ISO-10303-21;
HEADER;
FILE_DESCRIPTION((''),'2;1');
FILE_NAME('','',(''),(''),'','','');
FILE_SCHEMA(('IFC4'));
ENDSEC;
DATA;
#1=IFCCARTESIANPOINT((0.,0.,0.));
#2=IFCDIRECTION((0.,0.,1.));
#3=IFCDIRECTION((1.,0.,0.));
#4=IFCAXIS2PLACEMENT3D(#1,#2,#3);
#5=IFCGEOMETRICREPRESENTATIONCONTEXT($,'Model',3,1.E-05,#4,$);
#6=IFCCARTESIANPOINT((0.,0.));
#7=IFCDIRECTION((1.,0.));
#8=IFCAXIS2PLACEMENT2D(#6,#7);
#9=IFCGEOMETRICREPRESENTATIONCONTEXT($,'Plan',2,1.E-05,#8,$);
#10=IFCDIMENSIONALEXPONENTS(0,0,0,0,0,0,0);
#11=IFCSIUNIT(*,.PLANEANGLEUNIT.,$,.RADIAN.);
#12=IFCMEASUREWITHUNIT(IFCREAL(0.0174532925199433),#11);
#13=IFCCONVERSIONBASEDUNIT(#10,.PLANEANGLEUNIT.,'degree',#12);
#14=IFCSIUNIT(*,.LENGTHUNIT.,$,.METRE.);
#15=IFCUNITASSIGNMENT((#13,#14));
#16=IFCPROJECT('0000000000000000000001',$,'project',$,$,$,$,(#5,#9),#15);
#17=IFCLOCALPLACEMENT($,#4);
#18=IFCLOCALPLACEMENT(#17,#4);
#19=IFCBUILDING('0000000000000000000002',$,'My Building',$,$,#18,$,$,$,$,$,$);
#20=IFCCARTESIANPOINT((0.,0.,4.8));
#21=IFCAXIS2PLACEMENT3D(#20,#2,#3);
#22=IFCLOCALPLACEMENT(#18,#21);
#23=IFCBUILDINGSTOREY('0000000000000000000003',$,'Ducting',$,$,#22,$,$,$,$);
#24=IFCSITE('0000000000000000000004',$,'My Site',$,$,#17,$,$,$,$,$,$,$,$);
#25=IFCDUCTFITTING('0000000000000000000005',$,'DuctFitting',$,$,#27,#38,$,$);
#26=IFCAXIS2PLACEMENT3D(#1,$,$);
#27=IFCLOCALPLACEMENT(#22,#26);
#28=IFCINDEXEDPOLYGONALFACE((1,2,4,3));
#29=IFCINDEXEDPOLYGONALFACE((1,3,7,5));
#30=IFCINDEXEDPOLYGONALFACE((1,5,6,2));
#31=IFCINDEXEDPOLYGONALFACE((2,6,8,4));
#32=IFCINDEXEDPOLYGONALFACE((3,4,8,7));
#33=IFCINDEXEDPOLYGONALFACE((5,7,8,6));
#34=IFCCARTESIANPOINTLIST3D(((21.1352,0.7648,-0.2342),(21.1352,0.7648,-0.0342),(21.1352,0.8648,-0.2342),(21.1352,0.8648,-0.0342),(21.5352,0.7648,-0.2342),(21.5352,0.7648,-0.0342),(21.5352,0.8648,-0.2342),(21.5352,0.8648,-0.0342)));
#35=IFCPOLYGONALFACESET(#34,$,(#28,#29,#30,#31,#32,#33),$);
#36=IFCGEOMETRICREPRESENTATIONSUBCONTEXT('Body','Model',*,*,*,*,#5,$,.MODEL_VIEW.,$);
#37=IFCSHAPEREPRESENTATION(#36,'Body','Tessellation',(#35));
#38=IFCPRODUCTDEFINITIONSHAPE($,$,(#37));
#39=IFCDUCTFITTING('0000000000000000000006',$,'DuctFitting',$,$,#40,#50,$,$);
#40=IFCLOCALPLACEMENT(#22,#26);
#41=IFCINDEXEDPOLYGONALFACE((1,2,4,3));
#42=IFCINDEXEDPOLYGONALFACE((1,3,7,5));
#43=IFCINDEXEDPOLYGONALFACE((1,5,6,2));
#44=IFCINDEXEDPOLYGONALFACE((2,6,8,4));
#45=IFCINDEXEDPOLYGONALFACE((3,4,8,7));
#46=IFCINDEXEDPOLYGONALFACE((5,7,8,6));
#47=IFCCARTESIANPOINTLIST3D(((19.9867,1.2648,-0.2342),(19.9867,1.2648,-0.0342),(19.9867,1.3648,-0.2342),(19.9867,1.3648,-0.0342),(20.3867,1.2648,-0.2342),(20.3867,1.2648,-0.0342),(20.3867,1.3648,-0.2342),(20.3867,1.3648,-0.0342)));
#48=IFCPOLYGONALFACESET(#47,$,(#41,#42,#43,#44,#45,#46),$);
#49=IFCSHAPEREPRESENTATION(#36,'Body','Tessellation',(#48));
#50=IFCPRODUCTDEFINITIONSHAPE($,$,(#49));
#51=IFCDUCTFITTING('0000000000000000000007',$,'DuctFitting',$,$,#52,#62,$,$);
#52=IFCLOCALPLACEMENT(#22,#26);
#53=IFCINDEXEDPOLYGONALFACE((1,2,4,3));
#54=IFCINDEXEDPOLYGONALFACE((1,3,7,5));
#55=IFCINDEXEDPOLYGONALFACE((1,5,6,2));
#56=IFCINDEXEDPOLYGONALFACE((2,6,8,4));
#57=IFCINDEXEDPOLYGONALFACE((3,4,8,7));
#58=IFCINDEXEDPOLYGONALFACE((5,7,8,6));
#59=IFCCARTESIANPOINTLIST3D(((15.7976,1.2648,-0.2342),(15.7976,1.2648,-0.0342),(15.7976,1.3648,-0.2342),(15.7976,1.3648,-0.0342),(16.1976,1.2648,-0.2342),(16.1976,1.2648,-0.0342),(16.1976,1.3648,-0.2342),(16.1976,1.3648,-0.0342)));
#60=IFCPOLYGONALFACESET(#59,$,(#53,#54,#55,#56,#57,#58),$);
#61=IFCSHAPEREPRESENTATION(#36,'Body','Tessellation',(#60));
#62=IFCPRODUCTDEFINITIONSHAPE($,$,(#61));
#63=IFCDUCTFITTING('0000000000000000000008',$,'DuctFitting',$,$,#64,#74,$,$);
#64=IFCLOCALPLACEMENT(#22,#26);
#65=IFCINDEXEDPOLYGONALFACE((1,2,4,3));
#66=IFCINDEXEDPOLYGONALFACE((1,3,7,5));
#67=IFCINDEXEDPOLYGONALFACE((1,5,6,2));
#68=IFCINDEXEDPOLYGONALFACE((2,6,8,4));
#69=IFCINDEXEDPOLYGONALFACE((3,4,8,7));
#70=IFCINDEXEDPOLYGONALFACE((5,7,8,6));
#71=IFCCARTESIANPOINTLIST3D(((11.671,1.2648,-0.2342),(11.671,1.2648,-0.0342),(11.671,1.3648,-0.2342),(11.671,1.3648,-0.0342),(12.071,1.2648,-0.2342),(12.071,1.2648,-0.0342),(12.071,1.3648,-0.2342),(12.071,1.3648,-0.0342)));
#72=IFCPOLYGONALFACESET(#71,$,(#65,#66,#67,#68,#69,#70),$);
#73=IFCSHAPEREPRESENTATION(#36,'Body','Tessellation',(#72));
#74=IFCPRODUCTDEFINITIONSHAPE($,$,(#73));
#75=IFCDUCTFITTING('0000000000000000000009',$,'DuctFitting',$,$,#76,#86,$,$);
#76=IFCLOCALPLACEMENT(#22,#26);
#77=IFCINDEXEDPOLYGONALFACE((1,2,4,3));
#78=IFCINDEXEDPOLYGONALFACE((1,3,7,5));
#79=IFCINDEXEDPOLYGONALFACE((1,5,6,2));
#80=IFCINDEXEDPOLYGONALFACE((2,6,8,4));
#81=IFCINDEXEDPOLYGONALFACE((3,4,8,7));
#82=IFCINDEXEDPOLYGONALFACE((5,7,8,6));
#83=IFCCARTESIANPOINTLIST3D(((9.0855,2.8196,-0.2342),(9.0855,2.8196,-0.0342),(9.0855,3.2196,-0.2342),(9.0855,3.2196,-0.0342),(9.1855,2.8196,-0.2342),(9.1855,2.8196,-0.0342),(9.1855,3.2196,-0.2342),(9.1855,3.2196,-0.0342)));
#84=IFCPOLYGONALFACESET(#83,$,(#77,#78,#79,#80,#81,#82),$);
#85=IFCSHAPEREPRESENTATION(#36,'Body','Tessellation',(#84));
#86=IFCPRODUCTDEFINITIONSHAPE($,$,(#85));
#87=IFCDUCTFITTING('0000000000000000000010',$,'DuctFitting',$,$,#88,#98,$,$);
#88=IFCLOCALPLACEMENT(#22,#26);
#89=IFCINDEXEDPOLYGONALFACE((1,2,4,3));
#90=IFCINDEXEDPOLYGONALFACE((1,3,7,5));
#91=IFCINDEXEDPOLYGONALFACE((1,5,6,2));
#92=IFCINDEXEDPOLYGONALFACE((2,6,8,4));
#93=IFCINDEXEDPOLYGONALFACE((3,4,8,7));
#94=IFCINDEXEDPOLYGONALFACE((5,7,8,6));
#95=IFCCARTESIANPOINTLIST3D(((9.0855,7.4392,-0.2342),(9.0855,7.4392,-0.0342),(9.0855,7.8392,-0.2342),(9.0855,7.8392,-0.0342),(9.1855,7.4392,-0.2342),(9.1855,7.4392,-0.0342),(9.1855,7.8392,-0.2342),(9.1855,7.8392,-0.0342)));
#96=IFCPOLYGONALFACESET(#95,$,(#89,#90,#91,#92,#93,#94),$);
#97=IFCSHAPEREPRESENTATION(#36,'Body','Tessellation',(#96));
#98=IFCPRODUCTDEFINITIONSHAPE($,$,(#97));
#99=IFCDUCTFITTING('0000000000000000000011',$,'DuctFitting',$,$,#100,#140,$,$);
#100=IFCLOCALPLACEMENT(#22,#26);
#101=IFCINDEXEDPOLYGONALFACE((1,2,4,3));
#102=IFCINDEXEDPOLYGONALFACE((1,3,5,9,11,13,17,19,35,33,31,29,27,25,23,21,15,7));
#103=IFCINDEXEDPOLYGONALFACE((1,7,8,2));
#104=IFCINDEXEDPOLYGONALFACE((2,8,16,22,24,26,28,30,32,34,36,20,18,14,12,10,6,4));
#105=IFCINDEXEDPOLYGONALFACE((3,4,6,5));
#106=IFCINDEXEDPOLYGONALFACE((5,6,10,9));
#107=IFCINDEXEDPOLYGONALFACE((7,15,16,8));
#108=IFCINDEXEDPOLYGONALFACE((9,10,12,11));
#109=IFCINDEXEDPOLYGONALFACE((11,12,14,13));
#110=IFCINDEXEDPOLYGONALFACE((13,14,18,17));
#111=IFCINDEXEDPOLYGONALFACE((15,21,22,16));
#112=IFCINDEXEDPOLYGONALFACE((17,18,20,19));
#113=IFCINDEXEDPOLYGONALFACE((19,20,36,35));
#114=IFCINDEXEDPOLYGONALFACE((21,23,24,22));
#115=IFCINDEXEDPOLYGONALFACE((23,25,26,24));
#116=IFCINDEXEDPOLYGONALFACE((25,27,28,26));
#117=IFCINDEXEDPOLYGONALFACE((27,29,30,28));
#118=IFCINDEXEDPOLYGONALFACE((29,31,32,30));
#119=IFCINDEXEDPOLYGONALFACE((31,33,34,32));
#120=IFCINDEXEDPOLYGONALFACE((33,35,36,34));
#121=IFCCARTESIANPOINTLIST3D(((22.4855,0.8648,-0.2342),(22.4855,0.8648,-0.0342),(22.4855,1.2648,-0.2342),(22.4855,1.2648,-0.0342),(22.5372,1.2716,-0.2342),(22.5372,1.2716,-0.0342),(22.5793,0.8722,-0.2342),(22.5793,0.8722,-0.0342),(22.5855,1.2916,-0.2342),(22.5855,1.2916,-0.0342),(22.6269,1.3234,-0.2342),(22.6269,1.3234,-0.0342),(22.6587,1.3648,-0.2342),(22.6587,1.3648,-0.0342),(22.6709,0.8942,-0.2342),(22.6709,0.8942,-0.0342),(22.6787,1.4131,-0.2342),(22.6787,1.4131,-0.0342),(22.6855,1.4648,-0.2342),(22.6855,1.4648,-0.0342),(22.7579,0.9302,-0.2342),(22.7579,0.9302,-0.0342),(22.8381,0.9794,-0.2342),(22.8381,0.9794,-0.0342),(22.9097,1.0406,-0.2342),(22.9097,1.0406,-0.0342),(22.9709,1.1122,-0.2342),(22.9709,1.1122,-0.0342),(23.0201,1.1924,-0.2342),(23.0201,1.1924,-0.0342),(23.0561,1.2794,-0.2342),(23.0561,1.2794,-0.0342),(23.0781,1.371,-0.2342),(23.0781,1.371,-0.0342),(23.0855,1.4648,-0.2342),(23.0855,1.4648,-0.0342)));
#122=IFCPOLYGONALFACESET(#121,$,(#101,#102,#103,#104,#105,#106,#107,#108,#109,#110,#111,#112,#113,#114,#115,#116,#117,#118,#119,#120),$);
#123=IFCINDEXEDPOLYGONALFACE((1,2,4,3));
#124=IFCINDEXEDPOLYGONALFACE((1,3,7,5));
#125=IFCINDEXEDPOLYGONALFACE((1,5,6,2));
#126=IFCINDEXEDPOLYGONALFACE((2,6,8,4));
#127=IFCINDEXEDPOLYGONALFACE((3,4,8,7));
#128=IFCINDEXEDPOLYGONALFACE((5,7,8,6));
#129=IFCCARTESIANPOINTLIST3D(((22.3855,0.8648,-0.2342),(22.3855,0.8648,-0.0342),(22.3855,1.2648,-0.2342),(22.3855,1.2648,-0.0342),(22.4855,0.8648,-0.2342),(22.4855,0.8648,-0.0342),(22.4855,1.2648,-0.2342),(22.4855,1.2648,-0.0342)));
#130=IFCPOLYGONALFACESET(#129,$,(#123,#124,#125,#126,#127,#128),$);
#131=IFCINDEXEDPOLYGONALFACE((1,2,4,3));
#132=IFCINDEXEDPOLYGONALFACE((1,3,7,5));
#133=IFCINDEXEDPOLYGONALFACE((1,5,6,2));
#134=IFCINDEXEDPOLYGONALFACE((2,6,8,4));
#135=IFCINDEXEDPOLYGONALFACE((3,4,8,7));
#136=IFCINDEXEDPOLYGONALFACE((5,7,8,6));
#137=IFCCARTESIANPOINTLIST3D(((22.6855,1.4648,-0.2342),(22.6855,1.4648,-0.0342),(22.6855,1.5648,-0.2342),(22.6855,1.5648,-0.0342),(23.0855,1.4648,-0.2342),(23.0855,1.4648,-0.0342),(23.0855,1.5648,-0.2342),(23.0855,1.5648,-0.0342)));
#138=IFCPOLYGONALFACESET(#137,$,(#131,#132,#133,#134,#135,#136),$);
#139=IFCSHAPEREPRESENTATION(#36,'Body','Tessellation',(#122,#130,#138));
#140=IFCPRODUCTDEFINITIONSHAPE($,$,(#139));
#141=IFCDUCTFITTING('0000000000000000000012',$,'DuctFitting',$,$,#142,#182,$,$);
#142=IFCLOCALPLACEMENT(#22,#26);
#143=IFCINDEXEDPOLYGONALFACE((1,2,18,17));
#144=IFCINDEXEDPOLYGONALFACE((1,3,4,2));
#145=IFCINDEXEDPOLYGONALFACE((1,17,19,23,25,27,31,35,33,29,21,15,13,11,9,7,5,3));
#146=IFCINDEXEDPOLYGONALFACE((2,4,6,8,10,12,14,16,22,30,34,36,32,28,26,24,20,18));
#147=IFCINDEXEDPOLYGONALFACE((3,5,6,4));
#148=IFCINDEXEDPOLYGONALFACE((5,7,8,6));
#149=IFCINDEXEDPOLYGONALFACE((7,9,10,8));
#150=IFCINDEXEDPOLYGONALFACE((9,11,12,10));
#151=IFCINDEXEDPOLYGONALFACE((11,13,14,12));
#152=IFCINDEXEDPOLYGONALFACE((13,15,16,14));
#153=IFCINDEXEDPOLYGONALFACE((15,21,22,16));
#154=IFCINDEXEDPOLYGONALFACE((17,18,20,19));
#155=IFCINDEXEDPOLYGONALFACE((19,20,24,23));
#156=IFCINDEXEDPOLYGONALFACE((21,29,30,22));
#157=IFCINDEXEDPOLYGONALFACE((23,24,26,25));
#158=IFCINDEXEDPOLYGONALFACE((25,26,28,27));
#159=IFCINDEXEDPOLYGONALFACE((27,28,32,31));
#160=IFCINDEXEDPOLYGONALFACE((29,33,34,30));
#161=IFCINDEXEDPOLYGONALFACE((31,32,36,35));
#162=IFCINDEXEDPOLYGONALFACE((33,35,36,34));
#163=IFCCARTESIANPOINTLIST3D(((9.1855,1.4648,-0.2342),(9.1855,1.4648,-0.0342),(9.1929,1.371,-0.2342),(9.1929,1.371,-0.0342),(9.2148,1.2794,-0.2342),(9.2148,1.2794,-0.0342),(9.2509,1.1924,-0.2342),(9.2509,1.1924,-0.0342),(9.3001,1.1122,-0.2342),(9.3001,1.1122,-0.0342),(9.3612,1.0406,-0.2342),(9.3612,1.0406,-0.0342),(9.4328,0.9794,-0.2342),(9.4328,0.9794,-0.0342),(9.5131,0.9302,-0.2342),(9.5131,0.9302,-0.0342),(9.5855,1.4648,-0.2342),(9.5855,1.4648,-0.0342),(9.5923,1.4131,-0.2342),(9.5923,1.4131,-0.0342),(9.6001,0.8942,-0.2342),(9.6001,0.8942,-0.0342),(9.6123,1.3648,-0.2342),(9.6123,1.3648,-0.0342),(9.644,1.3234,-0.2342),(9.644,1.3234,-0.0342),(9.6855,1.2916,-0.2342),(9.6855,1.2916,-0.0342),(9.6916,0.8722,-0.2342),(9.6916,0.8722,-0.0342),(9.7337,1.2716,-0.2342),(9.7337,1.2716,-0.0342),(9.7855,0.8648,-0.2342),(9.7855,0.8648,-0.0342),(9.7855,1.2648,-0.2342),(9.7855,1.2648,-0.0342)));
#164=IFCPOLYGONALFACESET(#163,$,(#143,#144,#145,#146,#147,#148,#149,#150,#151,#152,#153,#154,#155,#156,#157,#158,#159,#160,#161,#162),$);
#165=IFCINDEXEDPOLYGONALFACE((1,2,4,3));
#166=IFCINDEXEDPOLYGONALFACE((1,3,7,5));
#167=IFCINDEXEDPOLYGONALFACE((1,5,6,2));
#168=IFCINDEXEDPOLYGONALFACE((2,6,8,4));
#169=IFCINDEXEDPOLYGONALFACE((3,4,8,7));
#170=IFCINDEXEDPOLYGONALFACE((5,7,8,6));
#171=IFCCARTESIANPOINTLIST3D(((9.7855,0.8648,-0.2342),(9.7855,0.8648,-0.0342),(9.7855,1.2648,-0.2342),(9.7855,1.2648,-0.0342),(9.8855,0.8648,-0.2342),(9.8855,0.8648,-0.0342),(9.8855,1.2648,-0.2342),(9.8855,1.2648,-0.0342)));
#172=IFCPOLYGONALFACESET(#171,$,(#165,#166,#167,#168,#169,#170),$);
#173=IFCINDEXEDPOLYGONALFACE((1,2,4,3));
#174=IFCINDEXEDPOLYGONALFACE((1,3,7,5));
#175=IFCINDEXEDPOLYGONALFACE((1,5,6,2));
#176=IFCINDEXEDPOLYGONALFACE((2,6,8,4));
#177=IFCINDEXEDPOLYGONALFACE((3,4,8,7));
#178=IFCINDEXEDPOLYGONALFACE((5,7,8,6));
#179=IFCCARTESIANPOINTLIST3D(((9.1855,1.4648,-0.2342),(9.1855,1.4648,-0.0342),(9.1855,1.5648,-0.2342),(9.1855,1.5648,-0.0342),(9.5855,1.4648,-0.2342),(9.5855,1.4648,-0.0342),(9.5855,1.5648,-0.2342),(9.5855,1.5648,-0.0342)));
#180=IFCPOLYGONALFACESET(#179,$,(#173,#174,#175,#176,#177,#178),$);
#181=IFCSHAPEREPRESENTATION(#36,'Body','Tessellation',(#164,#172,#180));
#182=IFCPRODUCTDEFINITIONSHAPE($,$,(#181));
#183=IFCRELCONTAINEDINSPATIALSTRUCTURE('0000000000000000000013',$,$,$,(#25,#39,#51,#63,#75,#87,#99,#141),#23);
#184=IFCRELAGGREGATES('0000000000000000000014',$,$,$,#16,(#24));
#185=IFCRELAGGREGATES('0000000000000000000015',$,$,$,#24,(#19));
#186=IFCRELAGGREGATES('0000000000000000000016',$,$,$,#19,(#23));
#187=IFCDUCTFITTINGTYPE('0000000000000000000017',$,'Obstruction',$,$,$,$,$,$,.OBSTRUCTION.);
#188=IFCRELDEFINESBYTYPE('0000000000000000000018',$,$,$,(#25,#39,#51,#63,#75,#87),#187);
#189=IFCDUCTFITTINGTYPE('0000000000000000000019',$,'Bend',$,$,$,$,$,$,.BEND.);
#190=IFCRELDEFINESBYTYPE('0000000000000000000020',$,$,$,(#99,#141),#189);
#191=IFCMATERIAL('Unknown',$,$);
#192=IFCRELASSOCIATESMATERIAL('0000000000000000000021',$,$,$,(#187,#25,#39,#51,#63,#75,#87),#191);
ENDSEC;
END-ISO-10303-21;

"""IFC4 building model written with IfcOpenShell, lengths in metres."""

from ifc_helpers import new_model, entity, si_unit, converted_unit, frame, origin_with_axes, origin_2d_with_axis, place, context, subcontext, project, spatial, line, arc, indexed_curve, rectangle, outline, extrude, source, transform, mapped, material, material_profile, profile_set, profile_usage, type_object, type_shapes, element, save


model = new_model("IFC4")

# Units and contexts
model_context = context("Model", 3, precision=1e-05, world=origin_with_axes())
plan_context = context("Plan", 2, precision=1e-05, world=origin_2d_with_axis())
body_context = subcontext(model_context, "Body", "Model", "MODEL_VIEW")
ifc_project = project(units=[converted_unit("PLANEANGLEUNIT", "degree", entity("IfcReal", 0.0174532925199433), si_unit("PLANEANGLEUNIT", "RADIAN"), dimensions=[0, 0, 0, 0, 0, 0, 0]), si_unit("LENGTHUNIT", "METRE")], contexts=[model_context, plan_context])

# Site, building, storey
site_placement = place(None, origin_with_axes())
site = spatial("IfcSite", under=ifc_project, at=site_placement, Name="My Site")
building_placement = place(site_placement, origin_with_axes())
building = spatial("IfcBuilding", under=site, at=building_placement, Name="My Building")
storey_placement = place(building_placement, frame((0.0, 0.0, 4.8), z_axis=(0.0, 0.0, 1.0), x_axis=(1.0, 0.0, 0.0)))
storey = spatial("IfcBuildingStorey", under=building, at=storey_placement, Name="Ducting")

# Shared definitions
ifc_material = material(Name="Unknown")

# Duct fittings
ifc_material_profile_1 = material_profile(ifc_material, rectangle(XDim=0.4, YDim=0.2))
ifc_profile_set_1 = profile_set([ifc_material_profile_1])
duct_fitting_type_1 = type_object("IfcDuctFittingType", Name="Obstruction", PredefinedType="OBSTRUCTION", material=ifc_profile_set_1)
ifc_profile_usage_1 = profile_usage(ifc_profile_set_1, cardinal=5)
duct_fitting_1_placement = place(storey_placement, frame((21.3352, 0.8648, -0.1342), z_axis=(0.0, -1.0, -0.000001), x_axis=(1.0, 0.0, 0.0)))
element("IfcDuctFitting", 1, at=duct_fitting_1_placement, inside=storey, type_object=duct_fitting_type_1, material=ifc_profile_usage_1, Name="DuctFitting", context=body_context, shape_type="SweptSolid", body=[
    extrude(rectangle(XDim=0.4, YDim=0.2), origin_with_axes(), (0.0, 0.0, 1.0), 0.1),
])
ifc_profile_usage_2 = profile_usage(ifc_profile_set_1, cardinal=5)
duct_fitting_2_placement = place(storey_placement, frame((20.1867, 1.3648, -0.1342), z_axis=(0.000001, -1.0, 0.0), x_axis=(1.0, 0.000001, 0.0)))
element("IfcDuctFitting", 2, at=duct_fitting_2_placement, inside=storey, type_object=duct_fitting_type_1, material=ifc_profile_usage_2, Name="DuctFitting", context=body_context, shape_type="SweptSolid", body=[
    extrude(rectangle(XDim=0.4, YDim=0.2), origin_with_axes(), (0.0, 0.0, 1.0), 0.1),
])
ifc_profile_usage_3 = profile_usage(ifc_profile_set_1, cardinal=5)
duct_fitting_3_placement = place(storey_placement, frame((15.9976, 1.3648, -0.1342), z_axis=(0.000001, -1.0, 0.0), x_axis=(1.0, 0.000001, 0.0)))
element("IfcDuctFitting", 3, at=duct_fitting_3_placement, inside=storey, type_object=duct_fitting_type_1, material=ifc_profile_usage_3, Name="DuctFitting", context=body_context, shape_type="SweptSolid", body=[
    extrude(rectangle(XDim=0.4, YDim=0.2), origin_with_axes(), (0.0, 0.0, 1.0), 0.1),
])
ifc_profile_usage_4 = profile_usage(ifc_profile_set_1, cardinal=5)
duct_fitting_4_placement = place(storey_placement, frame((11.871, 1.3648, -0.1342), z_axis=(0.000001, -1.0, 0.0), x_axis=(1.0, 0.000001, 0.0)))
element("IfcDuctFitting", 4, at=duct_fitting_4_placement, inside=storey, type_object=duct_fitting_type_1, material=ifc_profile_usage_4, Name="DuctFitting", context=body_context, shape_type="SweptSolid", body=[
    extrude(rectangle(XDim=0.4, YDim=0.2), origin_with_axes(), (0.0, 0.0, 1.0), 0.1),
])
ifc_profile_usage_5 = profile_usage(ifc_profile_set_1, cardinal=5)
duct_fitting_5_placement = place(storey_placement, frame((9.1855, 3.0196, -0.1342), z_axis=(-1.0, 0.0, 0.0), x_axis=(0.0, -1.0, 0.0)))
element("IfcDuctFitting", 5, at=duct_fitting_5_placement, inside=storey, type_object=duct_fitting_type_1, material=ifc_profile_usage_5, Name="DuctFitting", context=body_context, shape_type="SweptSolid", body=[
    extrude(rectangle(XDim=0.4, YDim=0.2), origin_with_axes(), (0.0, 0.0, 1.0), 0.1),
])
ifc_profile_usage_6 = profile_usage(ifc_profile_set_1, cardinal=5)
duct_fitting_6_placement = place(storey_placement, frame((9.1855, 7.6392, -0.1342), z_axis=(-1.0, 0.0, 0.0), x_axis=(0.0, -1.0, 0.0)))
element("IfcDuctFitting", 6, at=duct_fitting_6_placement, inside=storey, type_object=duct_fitting_type_1, material=ifc_profile_usage_6, Name="DuctFitting", context=body_context, shape_type="SweptSolid", body=[
    extrude(rectangle(XDim=0.4, YDim=0.2), origin_with_axes(), (0.0, 0.0, 1.0), 0.1),
])
duct_fitting_type_2 = type_object("IfcDuctFittingType", Name="Bend", PredefinedType="BEND")
shared_shape = source(origin_with_axes(), body_context, "Body", "SweptSolid", [
    extrude(outline(indexed_curve([(-0.2, 0.0), (-0.2586, -0.1414), (-0.4, -0.2), (-0.4, -0.6), (0.0243, -0.4243), (0.2, 0.0)], segments=[arc(1, 2, 3), line(3, 4), arc(4, 5, 6), line(6, 1)])), frame((0.0, -0.1, -0.1), z_axis=(0.0, -1.0, 0.0), x_axis=(1.0, 0.0, 0.0)), (0.0, 0.0, -1.0), 0.2),
    extrude(rectangle(XDim=0.4, YDim=0.2), origin_with_axes(), (0.0, 0.0, -1.0), 0.1),
    extrude(rectangle(XDim=0.4, YDim=0.2), frame((-0.4, 0.0, -0.5), z_axis=(-1.0, 0.0, 0.0), x_axis=(0.0, 0.0, -1.0)), (0.0, 0.0, 1.0), 0.1),
])
type_shapes(duct_fitting_type_2, [shared_shape])
for number, where, z_axis, x_axis, name in (
    (7, (22.3855, 1.0648, -0.1342), (-1.0, 0.0, 0.0), (0.0, -1.0, 0.0), "DuctFitting"),
    (8, (9.8855, 1.0648, -0.1342), (1.0, 0.0, 0.0), (0.0, -1.0, 0.0), "DuctFitting"),
):
    element("IfcDuctFitting", number, at=place(storey_placement, frame(where, z_axis=z_axis, x_axis=x_axis)), inside=storey, type_object=duct_fitting_type_2, Name=name, context=body_context, shape_type="MappedRepresentation", body=[
        mapped(shared_shape, transform((0.0, 0.0, 0.0), x_axis=(1.0, 0.0, 0.0), y_axis=(0.0, 1.0, 0.0), z_axis=(0.0, 0.0, 1.0), scale=1.0)),
    ])

save(model, "model.ifc")
